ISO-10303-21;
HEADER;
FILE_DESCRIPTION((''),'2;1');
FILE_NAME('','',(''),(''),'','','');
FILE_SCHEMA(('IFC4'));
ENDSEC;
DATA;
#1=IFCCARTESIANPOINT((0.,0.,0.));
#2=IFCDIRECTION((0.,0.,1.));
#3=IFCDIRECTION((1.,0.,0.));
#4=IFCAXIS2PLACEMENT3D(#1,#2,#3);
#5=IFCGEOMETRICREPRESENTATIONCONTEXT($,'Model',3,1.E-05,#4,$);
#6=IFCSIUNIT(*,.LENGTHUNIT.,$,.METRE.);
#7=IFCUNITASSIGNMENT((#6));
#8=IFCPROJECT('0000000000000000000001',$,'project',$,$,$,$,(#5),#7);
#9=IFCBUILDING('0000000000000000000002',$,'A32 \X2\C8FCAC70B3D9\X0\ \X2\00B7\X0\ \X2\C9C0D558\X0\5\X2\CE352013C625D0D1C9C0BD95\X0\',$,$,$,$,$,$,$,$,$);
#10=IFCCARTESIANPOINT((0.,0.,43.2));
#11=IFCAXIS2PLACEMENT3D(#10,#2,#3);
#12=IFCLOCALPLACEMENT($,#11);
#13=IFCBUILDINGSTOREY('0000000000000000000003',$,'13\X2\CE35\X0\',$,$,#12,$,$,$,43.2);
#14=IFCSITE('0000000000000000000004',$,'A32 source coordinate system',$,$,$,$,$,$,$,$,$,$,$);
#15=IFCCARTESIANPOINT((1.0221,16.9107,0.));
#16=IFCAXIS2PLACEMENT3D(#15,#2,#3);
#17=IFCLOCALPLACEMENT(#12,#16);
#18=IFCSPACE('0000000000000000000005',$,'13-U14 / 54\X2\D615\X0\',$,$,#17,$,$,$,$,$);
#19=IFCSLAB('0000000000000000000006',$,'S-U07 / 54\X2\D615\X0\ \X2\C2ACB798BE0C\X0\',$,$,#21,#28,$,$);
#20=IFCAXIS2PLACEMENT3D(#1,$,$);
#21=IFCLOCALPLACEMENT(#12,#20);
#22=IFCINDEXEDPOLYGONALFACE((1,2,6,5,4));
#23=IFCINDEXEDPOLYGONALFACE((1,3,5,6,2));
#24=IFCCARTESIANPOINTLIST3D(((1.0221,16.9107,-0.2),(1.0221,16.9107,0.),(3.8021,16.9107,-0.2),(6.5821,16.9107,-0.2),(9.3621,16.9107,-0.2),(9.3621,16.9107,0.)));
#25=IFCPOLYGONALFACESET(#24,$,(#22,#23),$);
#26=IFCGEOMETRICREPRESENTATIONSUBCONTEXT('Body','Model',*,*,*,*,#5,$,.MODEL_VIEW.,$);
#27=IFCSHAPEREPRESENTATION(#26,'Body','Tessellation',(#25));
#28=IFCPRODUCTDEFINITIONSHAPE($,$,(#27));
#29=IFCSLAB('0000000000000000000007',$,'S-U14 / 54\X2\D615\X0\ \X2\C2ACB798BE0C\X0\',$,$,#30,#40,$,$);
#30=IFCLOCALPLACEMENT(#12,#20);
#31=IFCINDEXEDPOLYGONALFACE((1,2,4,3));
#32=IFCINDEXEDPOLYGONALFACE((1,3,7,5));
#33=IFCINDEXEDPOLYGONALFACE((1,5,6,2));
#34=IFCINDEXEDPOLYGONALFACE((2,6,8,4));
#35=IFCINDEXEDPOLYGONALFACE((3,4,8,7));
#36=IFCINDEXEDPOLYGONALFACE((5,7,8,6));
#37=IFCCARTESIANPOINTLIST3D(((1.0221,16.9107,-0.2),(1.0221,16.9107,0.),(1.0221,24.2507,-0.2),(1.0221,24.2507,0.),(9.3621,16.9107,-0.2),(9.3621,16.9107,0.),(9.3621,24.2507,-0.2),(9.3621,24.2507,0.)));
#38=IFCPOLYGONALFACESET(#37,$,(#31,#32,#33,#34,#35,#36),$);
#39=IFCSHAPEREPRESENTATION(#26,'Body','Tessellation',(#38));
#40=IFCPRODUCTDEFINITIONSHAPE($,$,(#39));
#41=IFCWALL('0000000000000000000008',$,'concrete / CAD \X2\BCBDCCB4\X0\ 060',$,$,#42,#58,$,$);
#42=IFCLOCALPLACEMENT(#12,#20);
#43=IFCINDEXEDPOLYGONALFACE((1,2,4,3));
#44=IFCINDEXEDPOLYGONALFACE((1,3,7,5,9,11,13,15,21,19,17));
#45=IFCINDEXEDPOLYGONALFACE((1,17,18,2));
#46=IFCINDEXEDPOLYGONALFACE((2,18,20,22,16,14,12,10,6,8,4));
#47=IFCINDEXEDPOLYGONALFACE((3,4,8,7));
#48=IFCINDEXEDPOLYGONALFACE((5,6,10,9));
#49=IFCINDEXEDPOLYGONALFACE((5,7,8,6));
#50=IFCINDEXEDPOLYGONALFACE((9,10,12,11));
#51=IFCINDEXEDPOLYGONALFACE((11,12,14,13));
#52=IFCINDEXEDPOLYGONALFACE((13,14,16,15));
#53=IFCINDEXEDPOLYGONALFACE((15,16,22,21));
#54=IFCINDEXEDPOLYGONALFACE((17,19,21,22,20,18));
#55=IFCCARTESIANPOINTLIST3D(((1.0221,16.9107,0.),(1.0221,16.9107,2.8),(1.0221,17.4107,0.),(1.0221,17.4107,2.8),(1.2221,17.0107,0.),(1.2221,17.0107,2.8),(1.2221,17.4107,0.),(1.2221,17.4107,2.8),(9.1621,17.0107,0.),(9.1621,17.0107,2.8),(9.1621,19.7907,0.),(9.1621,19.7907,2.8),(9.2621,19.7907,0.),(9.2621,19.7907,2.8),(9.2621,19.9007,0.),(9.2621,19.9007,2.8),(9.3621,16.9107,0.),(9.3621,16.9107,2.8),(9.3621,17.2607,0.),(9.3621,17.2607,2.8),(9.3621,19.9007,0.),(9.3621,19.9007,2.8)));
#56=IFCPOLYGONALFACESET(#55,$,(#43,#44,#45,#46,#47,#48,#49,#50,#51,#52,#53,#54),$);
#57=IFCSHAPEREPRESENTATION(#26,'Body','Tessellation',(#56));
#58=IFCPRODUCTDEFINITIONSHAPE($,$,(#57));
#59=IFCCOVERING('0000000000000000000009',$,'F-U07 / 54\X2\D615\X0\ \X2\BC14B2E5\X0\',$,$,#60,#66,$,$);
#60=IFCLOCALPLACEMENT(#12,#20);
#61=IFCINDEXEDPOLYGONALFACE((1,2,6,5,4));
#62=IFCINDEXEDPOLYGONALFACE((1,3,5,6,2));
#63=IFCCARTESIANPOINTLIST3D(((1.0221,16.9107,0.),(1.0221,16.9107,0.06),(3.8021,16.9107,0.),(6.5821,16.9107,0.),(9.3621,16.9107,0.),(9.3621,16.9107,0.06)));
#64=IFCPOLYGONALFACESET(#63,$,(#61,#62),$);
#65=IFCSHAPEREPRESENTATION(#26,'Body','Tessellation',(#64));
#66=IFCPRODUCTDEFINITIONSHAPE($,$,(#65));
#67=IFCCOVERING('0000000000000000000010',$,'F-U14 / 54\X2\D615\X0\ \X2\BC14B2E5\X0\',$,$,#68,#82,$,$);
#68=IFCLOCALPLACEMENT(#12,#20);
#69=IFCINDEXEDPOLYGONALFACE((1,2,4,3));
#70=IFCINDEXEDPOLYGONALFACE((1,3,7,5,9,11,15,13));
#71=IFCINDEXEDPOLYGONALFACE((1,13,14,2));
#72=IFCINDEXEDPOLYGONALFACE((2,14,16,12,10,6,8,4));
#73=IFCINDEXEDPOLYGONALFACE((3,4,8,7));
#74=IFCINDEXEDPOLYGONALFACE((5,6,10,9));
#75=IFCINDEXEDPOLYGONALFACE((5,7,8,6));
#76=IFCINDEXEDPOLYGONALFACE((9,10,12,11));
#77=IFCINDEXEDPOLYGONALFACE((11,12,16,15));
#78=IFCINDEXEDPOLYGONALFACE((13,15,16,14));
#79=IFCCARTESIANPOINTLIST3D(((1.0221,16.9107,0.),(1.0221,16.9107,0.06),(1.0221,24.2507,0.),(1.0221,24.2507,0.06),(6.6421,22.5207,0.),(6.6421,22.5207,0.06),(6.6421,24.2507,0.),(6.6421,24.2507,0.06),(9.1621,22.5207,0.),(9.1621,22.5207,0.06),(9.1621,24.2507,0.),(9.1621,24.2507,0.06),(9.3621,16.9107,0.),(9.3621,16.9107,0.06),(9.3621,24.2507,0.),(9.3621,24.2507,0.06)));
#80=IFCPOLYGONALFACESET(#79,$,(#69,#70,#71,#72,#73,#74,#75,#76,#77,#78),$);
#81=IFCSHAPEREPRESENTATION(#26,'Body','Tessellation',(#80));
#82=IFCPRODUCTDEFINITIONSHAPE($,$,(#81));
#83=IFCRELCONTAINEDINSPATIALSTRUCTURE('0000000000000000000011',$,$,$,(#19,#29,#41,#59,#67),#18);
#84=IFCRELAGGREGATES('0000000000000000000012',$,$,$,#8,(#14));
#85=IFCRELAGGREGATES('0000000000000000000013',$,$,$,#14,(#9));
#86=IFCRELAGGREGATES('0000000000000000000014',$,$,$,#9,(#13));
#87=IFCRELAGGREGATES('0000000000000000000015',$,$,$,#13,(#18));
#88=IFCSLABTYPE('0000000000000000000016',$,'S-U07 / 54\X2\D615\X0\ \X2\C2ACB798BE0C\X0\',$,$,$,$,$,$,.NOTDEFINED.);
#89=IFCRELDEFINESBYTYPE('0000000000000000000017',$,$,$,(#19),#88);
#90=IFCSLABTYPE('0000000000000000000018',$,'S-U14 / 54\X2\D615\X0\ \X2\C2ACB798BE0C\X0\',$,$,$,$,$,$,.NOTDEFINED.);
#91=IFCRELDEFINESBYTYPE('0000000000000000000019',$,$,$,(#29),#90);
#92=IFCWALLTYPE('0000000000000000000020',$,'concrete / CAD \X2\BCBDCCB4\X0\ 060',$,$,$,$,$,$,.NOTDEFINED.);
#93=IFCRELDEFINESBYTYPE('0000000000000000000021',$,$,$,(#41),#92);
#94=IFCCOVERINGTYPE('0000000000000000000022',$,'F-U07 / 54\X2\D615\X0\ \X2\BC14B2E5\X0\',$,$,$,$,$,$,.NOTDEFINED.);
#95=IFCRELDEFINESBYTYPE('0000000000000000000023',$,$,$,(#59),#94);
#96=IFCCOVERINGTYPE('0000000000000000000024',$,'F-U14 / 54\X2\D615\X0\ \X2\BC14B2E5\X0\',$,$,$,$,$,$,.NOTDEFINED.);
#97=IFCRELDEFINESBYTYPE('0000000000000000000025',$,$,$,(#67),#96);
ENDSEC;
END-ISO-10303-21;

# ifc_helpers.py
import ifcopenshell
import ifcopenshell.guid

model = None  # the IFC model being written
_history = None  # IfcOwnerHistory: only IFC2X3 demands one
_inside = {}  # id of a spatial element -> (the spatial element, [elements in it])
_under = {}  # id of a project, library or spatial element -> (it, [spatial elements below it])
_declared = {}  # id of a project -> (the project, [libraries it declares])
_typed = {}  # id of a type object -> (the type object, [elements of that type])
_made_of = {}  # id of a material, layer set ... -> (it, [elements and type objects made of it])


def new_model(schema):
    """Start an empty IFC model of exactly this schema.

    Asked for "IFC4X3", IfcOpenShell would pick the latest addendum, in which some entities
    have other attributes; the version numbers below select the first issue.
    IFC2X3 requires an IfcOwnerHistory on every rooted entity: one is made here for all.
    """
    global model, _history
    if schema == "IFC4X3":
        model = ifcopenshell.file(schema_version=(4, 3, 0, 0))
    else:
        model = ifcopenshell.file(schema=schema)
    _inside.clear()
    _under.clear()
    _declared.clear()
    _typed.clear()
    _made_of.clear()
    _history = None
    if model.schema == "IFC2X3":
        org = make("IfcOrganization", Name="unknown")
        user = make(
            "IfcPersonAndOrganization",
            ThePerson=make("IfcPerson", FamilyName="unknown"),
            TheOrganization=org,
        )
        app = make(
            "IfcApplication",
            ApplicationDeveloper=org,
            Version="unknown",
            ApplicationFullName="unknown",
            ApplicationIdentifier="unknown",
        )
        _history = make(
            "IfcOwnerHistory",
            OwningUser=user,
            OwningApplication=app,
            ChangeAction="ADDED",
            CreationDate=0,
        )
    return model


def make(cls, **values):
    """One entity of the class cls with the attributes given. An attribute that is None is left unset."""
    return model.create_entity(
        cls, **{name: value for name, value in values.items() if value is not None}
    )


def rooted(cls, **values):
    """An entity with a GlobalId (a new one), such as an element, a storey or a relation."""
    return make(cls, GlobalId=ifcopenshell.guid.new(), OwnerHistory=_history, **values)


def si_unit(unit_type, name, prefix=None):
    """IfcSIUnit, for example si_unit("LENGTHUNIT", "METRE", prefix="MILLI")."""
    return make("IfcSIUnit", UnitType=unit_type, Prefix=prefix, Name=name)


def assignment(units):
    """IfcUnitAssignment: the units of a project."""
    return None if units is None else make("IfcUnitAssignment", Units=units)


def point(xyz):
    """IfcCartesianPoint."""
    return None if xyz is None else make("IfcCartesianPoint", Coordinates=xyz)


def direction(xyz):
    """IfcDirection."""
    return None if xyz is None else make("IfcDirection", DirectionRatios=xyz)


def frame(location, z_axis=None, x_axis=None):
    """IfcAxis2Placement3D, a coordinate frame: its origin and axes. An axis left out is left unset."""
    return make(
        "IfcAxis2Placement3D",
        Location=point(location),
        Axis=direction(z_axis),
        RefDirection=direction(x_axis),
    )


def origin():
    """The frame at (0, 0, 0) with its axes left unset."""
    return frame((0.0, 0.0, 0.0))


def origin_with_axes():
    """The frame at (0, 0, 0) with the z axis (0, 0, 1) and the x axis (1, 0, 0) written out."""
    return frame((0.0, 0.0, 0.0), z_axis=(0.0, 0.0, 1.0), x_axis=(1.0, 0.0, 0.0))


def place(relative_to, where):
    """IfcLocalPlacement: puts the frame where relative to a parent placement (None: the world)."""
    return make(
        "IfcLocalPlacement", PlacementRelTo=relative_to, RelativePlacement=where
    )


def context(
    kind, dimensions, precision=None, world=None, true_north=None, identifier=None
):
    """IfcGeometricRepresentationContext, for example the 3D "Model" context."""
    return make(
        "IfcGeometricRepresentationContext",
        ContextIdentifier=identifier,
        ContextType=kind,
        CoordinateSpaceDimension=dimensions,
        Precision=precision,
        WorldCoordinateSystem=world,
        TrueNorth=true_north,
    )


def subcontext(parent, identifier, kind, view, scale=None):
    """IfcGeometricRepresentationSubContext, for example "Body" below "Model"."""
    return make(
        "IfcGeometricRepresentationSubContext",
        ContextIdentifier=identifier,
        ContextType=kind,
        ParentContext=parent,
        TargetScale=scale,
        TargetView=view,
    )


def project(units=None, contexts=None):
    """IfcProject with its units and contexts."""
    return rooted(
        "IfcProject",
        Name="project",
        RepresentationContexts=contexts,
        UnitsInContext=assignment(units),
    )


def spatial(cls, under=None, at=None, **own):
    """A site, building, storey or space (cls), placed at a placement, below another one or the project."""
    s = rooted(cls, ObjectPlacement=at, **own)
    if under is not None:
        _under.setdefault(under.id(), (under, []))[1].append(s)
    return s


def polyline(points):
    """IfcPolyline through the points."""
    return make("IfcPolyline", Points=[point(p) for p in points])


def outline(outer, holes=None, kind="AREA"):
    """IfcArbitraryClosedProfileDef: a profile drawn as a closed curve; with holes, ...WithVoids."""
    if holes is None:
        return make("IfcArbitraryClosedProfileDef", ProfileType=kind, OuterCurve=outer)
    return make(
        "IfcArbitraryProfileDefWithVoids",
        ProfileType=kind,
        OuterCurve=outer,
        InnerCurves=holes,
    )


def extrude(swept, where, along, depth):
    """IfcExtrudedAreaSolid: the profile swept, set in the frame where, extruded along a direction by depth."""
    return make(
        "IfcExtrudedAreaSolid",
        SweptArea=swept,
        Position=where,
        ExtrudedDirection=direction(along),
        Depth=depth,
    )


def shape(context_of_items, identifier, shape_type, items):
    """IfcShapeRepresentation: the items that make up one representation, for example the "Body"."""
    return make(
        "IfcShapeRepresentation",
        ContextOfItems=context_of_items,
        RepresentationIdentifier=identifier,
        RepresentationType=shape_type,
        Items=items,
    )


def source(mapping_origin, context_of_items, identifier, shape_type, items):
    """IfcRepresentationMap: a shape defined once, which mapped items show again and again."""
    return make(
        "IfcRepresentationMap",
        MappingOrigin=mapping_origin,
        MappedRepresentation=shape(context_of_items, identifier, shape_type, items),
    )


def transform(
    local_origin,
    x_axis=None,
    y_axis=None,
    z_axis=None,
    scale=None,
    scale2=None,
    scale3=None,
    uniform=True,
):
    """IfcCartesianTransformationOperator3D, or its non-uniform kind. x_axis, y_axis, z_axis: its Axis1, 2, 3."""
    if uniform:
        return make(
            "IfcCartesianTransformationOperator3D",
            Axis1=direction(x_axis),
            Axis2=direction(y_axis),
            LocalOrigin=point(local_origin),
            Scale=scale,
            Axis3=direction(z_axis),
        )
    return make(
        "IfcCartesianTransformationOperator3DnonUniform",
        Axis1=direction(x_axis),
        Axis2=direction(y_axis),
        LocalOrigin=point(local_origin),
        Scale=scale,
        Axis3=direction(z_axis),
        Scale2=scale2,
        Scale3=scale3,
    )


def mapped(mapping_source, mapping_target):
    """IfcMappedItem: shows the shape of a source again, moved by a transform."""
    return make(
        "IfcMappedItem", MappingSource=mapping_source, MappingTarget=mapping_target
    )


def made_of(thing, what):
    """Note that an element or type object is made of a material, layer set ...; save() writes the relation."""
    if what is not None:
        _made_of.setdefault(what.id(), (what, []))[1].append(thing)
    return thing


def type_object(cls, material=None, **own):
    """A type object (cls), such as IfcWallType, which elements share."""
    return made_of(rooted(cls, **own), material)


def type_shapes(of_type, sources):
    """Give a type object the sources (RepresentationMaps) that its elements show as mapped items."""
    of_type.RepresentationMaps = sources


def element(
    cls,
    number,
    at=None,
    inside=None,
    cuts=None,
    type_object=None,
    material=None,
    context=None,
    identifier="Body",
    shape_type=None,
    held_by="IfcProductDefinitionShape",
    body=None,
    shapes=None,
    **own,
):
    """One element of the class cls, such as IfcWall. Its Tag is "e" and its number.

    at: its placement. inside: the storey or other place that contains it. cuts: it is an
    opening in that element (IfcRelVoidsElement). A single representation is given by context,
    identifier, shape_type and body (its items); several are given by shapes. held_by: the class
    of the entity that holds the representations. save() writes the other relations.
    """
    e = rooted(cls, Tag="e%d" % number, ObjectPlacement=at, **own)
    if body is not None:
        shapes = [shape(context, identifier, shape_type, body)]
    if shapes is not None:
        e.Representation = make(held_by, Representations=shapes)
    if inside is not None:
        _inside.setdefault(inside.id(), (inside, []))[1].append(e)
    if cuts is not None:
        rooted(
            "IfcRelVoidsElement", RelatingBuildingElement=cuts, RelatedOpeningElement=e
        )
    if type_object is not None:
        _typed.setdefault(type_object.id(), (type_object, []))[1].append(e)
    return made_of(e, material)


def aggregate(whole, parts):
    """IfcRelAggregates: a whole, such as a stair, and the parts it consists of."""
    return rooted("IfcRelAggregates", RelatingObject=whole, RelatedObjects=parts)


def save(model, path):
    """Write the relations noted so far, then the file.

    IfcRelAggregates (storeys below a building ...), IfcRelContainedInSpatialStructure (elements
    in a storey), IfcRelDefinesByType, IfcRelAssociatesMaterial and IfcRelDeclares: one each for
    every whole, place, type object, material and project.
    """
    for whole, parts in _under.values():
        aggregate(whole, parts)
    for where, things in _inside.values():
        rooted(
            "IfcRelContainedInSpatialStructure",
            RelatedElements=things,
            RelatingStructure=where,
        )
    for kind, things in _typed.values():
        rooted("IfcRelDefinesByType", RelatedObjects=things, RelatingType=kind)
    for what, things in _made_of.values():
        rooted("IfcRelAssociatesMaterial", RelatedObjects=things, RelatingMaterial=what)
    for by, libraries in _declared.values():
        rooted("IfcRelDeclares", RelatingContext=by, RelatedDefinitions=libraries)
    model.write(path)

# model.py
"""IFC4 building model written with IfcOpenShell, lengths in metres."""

from ifc_helpers import new_model, si_unit, frame, origin, origin_with_axes, place, context, subcontext, project, spatial, polyline, outline, extrude, source, transform, mapped, type_object, type_shapes, element, save


model = new_model("IFC4")

# Units and contexts
model_context = context("Model", 3, precision=1e-05, world=origin_with_axes())
body_context = subcontext(model_context, "Body", "Model", "MODEL_VIEW")
ifc_project = project(units=[si_unit("LENGTHUNIT", "METRE")], contexts=[model_context])

# Site, building, storey, space
storey_placement = place(None, frame((0.0, 0.0, 43.2), z_axis=(0.0, 0.0, 1.0), x_axis=(1.0, 0.0, 0.0)))
space_1_placement = place(storey_placement, frame((1.0221, 16.9107, 0.0), z_axis=(0.0, 0.0, 1.0), x_axis=(1.0, 0.0, 0.0)))
site = spatial("IfcSite", under=ifc_project, Name="A32 source coordinate system")
building = spatial("IfcBuilding", under=site, Name="A32 주거동 · 지하5층–옥탑지붕")
storey = spatial("IfcBuildingStorey", under=building, at=storey_placement, Name="13층", Elevation=43.2)
space_1 = spatial("IfcSpace", under=storey, at=space_1_placement, Name="13-U14 / 54형")

# Slabs
slab_type_1 = type_object("IfcSlabType", Name="S-U07 / 54형 슬래브", PredefinedType="NOTDEFINED")
shared_shape_1 = source(origin(), body_context, "Body", "SweptSolid", [
    extrude(outline(polyline([(0.0, 0.0), (0.0, 0.0), (8.34, 0.0), (8.34, 0.0), (0.0, 0.0)])), frame((0.0, 0.0, -0.2)), (0.0, 0.0, 1.0), 0.2),
])
type_shapes(slab_type_1, [shared_shape_1])
slab_1_placement = place(space_1_placement, origin_with_axes())
element("IfcSlab", 1, at=slab_1_placement, inside=space_1, type_object=slab_type_1, Name="S-U07 / 54형 슬래브", context=body_context, shape_type="MappedRepresentation", body=[
    mapped(shared_shape_1, transform((0.0, 0.0, 0.0), scale=1.0)),
])
slab_type_2 = type_object("IfcSlabType", Name="S-U14 / 54형 슬래브", PredefinedType="NOTDEFINED")
shared_shape_2 = source(origin(), body_context, "Body", "SweptSolid", [
    extrude(outline(polyline([(0.0, 0.0), (0.0, 7.34), (8.34, 7.34), (8.34, 0.0), (0.0, 0.0)])), frame((0.0, 0.0, -0.2)), (0.0, 0.0, 1.0), 0.2),
])
type_shapes(slab_type_2, [shared_shape_2])
slab_2_placement = place(space_1_placement, origin_with_axes())
element("IfcSlab", 2, at=slab_2_placement, inside=space_1, type_object=slab_type_2, Name="S-U14 / 54형 슬래브", context=body_context, shape_type="MappedRepresentation", body=[
    mapped(shared_shape_2, transform((0.0, 0.0, 0.0), scale=1.0)),
])

# Wall
wall_type_1 = type_object("IfcWallType", Name="concrete / CAD 벽체 060", PredefinedType="NOTDEFINED")
shared_shape_3 = source(origin(), body_context, "Body", "SweptSolid", [
    extrude(outline(polyline([(0.2, 0.5), (0.2, 0.1), (8.14, 0.1), (8.14, 2.88), (8.24, 2.88), (8.24, 2.99), (8.34, 2.99), (8.34, 0.35), (8.34, 0.35), (8.34, 0.0), (0.0, 0.0), (0.0, 0.5), (0.2, 0.5)])), origin(), (0.0, 0.0, 1.0), 2.8),
])
type_shapes(wall_type_1, [shared_shape_3])
wall_1_placement = place(space_1_placement, origin_with_axes())
element("IfcWall", 3, at=wall_1_placement, inside=space_1, type_object=wall_type_1, Name="concrete / CAD 벽체 060", context=body_context, shape_type="MappedRepresentation", body=[
    mapped(shared_shape_3, transform((0.0, 0.0, 0.0), scale=1.0)),
])

# Coverings
covering_type_1 = type_object("IfcCoveringType", Name="F-U07 / 54형 바닥", PredefinedType="NOTDEFINED")
shared_shape_4 = source(origin(), body_context, "Body", "SweptSolid", [
    extrude(outline(polyline([(0.0, 0.0), (0.0, 0.0), (8.34, 0.0), (8.34, 0.0), (0.0, 0.0)])), origin(), (0.0, 0.0, 1.0), 0.06),
])
type_shapes(covering_type_1, [shared_shape_4])
covering_1_placement = place(space_1_placement, origin_with_axes())
element("IfcCovering", 4, at=covering_1_placement, inside=space_1, type_object=covering_type_1, Name="F-U07 / 54형 바닥", context=body_context, shape_type="MappedRepresentation", body=[
    mapped(shared_shape_4, transform((0.0, 0.0, 0.0), scale=1.0)),
])
covering_type_2 = type_object("IfcCoveringType", Name="F-U14 / 54형 바닥", PredefinedType="NOTDEFINED")
shared_shape_5 = source(origin(), body_context, "Body", "SweptSolid", [
    extrude(outline(polyline([(8.14, 7.34), (8.34, 7.34), (8.34, 0.0), (0.0, 0.0), (0.0, 7.34), (5.62, 7.34), (5.62, 5.61), (8.14, 5.61), (8.14, 7.34)])), origin(), (0.0, 0.0, 1.0), 0.06),
])
type_shapes(covering_type_2, [shared_shape_5])
covering_2_placement = place(space_1_placement, origin_with_axes())
element("IfcCovering", 5, at=covering_2_placement, inside=space_1, type_object=covering_type_2, Name="F-U14 / 54형 바닥", context=body_context, shape_type="MappedRepresentation", body=[
    mapped(shared_shape_5, transform((0.0, 0.0, 0.0), scale=1.0)),
])

save(model, "model.ifc")
